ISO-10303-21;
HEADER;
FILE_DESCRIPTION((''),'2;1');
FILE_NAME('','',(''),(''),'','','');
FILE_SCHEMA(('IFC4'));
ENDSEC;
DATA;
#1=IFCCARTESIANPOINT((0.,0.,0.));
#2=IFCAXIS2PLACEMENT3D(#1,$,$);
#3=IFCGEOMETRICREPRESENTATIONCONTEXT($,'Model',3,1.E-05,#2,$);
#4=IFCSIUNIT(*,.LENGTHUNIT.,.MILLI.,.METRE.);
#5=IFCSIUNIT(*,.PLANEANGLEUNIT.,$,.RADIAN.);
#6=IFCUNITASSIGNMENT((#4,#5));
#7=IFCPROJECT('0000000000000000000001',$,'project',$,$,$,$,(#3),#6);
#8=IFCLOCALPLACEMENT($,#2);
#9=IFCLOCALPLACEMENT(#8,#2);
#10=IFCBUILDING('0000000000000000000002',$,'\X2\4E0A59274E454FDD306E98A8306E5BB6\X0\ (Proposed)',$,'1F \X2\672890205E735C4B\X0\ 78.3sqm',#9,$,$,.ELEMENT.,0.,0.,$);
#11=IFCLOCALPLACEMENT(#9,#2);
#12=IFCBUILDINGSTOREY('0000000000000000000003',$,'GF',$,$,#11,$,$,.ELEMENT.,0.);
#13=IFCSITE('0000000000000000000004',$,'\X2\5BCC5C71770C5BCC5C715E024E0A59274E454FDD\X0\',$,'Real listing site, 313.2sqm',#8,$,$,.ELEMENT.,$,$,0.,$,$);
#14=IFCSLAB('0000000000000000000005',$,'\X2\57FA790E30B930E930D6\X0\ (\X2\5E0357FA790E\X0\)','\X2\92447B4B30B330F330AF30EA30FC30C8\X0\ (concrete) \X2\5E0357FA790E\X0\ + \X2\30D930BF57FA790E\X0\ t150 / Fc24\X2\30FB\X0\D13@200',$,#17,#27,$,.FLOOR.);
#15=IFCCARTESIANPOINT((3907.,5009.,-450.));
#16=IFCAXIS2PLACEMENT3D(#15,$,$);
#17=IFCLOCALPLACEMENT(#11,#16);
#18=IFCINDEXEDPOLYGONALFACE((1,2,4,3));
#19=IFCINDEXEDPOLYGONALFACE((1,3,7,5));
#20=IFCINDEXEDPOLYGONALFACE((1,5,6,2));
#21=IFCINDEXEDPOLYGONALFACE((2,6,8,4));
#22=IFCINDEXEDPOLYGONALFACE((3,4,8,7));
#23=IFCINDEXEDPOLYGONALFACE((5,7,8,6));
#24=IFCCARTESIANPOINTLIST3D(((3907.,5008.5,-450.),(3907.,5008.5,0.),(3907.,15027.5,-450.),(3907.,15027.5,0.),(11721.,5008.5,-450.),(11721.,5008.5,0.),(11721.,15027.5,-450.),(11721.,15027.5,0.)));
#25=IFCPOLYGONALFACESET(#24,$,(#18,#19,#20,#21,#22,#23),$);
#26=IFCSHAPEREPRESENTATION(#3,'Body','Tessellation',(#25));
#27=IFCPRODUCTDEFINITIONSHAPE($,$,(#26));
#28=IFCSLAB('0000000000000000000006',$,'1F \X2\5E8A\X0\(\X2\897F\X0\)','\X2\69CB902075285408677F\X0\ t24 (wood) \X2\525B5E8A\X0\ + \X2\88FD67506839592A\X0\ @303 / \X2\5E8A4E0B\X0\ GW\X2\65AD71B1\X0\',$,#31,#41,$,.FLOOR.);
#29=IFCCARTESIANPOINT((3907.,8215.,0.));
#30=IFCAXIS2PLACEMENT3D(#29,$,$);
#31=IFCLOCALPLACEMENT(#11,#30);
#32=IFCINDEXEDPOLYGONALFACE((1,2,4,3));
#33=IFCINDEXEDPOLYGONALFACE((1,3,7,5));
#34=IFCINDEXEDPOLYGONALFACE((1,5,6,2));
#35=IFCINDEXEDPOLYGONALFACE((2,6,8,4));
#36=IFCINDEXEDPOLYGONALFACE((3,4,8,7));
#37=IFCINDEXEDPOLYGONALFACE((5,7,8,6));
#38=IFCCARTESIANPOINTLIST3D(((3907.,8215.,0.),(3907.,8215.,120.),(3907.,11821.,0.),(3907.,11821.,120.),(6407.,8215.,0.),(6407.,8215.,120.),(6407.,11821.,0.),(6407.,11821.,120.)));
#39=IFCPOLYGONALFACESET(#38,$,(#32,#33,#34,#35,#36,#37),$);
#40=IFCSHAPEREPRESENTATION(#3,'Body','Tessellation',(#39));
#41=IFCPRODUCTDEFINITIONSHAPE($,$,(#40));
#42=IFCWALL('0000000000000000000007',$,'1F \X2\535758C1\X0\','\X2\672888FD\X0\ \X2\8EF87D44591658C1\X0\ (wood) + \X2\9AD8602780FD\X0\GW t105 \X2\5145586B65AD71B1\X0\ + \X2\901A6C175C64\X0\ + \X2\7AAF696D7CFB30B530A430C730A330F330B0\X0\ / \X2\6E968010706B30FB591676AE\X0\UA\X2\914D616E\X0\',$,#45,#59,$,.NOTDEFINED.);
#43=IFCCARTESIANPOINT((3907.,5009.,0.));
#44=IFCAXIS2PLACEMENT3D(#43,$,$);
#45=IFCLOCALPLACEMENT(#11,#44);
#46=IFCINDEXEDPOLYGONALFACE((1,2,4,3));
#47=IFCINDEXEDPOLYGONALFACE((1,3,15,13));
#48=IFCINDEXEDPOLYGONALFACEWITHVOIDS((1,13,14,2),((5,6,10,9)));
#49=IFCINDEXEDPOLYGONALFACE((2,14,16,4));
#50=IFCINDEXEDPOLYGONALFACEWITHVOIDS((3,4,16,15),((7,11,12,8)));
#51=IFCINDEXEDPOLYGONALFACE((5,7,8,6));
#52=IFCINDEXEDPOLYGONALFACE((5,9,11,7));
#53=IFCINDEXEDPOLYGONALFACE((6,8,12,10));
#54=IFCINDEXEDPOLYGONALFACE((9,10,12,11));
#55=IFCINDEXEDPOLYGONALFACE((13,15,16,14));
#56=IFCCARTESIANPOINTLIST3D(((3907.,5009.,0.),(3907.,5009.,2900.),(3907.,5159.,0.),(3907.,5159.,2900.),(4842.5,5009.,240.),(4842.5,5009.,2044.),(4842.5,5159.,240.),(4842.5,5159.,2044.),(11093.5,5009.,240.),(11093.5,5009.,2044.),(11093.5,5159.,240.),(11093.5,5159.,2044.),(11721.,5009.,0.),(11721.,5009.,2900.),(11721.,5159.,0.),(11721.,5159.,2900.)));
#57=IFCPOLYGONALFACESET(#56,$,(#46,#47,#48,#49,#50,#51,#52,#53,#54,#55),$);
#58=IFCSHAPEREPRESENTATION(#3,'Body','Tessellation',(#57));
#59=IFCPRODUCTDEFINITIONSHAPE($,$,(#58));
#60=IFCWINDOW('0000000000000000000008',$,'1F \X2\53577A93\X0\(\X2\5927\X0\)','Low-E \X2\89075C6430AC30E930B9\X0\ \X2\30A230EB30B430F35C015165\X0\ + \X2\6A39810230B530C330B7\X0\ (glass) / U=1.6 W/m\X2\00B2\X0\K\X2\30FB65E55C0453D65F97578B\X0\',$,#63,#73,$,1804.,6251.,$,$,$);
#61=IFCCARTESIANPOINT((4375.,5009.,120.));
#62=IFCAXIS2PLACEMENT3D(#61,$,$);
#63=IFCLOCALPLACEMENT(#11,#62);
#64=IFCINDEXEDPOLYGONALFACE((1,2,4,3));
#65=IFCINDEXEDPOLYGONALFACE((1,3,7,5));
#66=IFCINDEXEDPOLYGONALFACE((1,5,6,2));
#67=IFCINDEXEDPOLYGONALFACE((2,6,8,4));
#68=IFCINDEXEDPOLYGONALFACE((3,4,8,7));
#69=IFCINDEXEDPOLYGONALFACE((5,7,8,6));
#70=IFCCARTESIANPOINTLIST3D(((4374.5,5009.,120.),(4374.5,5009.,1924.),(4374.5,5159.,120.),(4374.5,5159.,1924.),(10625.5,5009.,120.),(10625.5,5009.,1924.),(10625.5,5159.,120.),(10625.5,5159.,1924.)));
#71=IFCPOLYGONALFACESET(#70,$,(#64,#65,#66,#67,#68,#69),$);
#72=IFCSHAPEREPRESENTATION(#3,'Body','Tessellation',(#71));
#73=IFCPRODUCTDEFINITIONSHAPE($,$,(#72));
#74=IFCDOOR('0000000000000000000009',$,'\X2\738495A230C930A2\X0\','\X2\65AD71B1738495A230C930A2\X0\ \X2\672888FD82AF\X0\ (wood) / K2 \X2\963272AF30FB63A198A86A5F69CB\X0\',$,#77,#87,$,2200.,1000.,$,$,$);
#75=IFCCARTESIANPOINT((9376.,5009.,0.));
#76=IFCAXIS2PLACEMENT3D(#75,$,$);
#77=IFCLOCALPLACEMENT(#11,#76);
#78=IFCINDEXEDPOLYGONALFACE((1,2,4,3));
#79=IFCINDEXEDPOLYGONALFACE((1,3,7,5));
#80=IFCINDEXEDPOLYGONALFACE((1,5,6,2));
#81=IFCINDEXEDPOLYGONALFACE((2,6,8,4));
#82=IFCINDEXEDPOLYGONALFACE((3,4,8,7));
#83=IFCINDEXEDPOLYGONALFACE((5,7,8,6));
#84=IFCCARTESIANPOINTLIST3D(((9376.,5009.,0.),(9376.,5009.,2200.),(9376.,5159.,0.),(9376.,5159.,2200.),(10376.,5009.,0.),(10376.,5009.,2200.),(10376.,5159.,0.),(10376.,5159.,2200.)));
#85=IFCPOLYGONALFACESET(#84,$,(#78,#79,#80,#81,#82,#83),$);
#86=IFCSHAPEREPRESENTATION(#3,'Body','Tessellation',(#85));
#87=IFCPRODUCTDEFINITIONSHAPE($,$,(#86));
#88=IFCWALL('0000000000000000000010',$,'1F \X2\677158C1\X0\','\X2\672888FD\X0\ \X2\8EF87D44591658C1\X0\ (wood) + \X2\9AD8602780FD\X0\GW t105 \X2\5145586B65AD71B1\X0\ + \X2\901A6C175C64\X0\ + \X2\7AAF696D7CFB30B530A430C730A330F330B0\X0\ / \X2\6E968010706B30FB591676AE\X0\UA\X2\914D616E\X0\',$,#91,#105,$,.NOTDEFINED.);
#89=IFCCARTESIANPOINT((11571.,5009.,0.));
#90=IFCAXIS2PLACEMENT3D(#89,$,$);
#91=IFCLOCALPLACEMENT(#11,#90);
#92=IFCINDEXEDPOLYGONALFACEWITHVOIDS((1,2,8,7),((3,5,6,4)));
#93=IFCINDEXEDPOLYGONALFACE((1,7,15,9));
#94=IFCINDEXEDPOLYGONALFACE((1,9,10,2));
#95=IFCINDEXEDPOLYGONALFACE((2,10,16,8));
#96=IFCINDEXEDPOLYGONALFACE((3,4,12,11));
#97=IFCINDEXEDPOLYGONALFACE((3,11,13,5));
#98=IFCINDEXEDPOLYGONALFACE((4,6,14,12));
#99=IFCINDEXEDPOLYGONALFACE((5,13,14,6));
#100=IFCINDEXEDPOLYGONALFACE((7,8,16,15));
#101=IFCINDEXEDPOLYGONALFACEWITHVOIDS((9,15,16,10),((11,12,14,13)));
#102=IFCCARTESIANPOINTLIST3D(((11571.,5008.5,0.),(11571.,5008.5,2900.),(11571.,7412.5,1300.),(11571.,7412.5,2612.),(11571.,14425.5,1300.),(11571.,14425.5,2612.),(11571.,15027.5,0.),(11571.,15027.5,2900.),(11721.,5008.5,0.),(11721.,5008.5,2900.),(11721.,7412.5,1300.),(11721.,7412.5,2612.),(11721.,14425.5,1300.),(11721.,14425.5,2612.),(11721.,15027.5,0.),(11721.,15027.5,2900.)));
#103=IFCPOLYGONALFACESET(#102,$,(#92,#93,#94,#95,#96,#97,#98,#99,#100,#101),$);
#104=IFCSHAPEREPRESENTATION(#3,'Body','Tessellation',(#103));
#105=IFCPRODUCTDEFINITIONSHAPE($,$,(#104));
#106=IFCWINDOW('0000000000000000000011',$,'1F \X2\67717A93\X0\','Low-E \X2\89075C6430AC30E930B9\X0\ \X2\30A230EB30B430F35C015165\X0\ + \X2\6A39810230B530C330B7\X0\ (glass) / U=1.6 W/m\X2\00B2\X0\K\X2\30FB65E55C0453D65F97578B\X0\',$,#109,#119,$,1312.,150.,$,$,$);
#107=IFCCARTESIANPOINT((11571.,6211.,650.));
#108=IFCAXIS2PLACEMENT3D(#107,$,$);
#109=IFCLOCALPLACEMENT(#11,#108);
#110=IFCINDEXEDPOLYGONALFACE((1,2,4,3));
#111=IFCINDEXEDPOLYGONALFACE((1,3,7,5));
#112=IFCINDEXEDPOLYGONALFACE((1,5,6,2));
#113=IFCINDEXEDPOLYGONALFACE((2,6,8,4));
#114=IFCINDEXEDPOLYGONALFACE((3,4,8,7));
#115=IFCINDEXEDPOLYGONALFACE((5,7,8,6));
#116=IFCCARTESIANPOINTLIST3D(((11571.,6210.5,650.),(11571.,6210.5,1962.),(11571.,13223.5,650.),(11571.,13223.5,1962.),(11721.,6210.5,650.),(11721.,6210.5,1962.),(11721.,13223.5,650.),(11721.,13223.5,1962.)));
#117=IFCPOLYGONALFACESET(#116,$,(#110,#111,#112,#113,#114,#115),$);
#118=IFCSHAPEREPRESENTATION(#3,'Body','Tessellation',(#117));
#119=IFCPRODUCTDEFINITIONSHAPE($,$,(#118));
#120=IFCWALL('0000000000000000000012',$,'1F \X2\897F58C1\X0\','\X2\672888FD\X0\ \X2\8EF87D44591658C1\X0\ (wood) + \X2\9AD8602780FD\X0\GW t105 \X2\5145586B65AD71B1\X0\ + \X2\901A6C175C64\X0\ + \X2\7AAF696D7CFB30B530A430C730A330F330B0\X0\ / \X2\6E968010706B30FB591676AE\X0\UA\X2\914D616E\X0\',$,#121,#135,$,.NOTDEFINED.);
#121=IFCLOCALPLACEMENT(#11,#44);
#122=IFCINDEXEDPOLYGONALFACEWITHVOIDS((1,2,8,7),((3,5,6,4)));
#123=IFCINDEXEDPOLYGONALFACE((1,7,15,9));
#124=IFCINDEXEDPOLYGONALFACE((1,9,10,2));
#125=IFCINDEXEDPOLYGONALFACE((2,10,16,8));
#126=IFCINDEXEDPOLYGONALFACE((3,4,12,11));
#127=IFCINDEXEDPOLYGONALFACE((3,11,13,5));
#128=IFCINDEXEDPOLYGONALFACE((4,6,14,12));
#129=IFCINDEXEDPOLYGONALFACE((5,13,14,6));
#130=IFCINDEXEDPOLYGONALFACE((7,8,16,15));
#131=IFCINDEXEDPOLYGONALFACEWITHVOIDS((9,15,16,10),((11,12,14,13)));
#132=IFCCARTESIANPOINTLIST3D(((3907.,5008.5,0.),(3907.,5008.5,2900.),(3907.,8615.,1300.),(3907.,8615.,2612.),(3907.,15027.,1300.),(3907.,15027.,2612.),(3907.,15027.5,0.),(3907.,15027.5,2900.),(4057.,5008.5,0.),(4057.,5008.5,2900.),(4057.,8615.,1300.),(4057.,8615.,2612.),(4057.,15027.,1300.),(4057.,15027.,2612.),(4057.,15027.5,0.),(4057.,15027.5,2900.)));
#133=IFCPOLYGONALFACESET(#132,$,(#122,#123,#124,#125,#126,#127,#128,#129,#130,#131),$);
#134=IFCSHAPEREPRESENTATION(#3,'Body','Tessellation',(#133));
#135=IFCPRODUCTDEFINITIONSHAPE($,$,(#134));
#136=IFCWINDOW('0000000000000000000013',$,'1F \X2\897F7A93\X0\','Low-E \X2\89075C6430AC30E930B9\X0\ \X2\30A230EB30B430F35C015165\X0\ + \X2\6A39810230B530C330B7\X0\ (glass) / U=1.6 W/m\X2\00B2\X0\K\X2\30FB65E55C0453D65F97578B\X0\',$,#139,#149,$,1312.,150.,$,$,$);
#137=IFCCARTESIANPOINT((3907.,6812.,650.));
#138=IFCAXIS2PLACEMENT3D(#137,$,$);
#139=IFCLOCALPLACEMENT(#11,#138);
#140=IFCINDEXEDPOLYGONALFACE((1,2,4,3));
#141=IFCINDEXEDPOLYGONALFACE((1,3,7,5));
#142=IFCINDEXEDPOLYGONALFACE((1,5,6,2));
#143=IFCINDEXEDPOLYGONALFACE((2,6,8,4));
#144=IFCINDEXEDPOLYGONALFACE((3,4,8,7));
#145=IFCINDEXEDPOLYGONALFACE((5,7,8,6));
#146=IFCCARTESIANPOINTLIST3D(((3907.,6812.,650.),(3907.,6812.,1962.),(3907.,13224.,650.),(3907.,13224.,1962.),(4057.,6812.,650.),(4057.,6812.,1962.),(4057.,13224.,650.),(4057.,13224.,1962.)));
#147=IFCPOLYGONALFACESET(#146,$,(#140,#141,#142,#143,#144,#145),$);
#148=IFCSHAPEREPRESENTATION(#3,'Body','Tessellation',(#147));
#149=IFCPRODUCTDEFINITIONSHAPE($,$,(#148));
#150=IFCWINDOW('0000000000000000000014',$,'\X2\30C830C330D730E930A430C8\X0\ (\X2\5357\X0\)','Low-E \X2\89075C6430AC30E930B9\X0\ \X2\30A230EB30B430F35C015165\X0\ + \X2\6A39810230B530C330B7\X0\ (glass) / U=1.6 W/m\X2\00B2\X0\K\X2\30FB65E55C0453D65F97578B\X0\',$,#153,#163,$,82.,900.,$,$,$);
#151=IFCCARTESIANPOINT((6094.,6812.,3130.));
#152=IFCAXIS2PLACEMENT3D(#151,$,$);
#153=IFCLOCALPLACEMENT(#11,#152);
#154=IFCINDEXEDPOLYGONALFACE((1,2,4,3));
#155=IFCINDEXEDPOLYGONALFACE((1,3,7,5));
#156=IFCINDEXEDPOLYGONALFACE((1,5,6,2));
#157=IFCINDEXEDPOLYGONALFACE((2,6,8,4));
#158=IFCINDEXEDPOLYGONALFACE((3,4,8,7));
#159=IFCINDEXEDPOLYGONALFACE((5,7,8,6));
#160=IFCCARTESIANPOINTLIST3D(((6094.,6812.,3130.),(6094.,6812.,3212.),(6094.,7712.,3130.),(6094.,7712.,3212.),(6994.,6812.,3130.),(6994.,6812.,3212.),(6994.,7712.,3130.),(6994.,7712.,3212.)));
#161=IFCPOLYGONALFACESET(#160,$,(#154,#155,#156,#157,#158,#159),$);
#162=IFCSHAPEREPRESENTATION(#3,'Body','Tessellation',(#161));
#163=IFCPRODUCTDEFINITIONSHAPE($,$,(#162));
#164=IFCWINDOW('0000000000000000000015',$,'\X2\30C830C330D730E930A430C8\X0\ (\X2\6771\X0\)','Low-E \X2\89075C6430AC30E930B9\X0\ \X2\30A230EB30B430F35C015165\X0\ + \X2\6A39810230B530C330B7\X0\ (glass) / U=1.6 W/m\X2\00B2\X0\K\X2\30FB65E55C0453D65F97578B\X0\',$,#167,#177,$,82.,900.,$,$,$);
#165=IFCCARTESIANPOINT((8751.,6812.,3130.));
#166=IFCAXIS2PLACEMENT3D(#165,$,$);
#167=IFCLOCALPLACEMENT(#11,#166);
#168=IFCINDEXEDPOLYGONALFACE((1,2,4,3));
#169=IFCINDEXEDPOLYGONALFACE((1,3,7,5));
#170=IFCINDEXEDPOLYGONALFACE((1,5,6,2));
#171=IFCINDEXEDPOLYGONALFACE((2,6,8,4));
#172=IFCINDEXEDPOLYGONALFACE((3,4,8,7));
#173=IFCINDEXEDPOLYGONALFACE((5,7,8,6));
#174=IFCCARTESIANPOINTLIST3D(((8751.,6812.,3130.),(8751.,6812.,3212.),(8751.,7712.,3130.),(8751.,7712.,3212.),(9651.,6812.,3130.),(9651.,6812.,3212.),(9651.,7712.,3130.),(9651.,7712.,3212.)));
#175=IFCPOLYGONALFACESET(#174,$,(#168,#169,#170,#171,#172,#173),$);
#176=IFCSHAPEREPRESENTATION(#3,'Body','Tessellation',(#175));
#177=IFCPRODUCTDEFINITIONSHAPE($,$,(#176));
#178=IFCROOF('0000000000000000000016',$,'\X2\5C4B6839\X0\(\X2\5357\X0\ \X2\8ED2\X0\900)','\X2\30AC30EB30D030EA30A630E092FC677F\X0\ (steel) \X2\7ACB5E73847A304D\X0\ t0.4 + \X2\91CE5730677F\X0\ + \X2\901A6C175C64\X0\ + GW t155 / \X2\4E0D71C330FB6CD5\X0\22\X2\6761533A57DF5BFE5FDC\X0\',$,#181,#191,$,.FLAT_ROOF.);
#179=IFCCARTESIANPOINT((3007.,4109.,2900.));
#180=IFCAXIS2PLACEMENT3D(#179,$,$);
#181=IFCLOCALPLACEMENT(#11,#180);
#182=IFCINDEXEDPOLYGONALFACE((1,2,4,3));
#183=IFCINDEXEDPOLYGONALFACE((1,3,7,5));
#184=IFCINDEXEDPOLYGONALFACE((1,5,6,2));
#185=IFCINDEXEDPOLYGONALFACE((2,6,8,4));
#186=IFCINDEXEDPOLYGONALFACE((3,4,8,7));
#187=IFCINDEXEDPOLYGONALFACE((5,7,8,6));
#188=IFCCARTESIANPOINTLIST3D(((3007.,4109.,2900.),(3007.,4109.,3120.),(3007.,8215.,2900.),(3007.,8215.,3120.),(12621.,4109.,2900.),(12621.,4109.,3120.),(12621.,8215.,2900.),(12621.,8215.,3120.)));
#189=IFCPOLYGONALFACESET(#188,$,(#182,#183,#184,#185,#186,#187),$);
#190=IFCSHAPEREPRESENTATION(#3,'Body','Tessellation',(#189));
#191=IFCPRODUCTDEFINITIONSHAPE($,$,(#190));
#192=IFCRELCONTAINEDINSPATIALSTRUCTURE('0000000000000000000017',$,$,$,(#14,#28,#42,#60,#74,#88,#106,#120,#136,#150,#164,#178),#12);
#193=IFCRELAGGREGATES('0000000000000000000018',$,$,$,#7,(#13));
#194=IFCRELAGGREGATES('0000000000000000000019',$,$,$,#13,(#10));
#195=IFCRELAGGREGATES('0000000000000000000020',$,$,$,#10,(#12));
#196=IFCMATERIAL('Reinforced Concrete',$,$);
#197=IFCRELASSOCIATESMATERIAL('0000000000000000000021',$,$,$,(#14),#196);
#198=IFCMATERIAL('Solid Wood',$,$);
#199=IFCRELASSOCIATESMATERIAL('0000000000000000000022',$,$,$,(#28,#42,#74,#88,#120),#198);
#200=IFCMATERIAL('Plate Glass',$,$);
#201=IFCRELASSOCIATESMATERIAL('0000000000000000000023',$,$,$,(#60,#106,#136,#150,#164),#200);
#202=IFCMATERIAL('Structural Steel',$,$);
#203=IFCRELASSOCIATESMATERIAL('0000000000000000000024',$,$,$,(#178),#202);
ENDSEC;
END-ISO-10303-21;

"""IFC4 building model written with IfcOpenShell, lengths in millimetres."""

from ifc_helpers import new_model, si_unit, frame, frame_2d, origin, place, context, project, spatial, rectangle, extrude, material, element, fill, save


model = new_model("IFC4")

# Units and contexts
model_context = context("Model", 3, precision=1e-05, world=origin())
ifc_project = project(units=[si_unit("LENGTHUNIT", "METRE", prefix="MILLI"), si_unit("PLANEANGLEUNIT", "RADIAN")], contexts=[model_context])

# Site, building, storey
site_placement = place(None, origin())
site = spatial("IfcSite", under=ifc_project, at=site_placement, Name="富山県富山市上大久保", ObjectType="Real listing site, 313.2sqm", CompositionType="ELEMENT", RefElevation=0.0)
building_placement = place(site_placement, origin())
building = spatial("IfcBuilding", under=site, at=building_placement, Name="上大久保の風の家 (Proposed)", ObjectType="1F 木造平屋 78.3sqm", CompositionType="ELEMENT", ElevationOfRefHeight=0.0, ElevationOfTerrain=0.0)
storey_placement = place(building_placement, origin())
storey = spatial("IfcBuildingStorey", under=building, at=storey_placement, Name="GF", CompositionType="ELEMENT", Elevation=0.0)

# Slabs
ifc_material_1 = material(Name="Reinforced Concrete")
slab_1_placement = place(storey_placement, frame((3907.0, 5009.0, -450.0)))
element("IfcSlab", 1, at=slab_1_placement, inside=storey, material=ifc_material_1, Name="基礎スラブ (布基礎)", Description="鉄筋コンクリート (concrete) 布基礎 + ベタ基礎 t150 / Fc24・D13@200", PredefinedType="FLOOR", context=model_context, shape_type="SweptSolid", body=[
    extrude(rectangle(XDim=7814.0, YDim=10019.0, at=frame_2d((3907.0, 5009.0))), frame((3907.0, 5009.0, -450.0)), (0.0, 0.0, 1.0), 450.0),
])
ifc_material_2 = material(Name="Solid Wood")
slab_2_placement = place(storey_placement, frame((3907.0, 8215.0, 0.0)))
element("IfcSlab", 2, at=slab_2_placement, inside=storey, material=ifc_material_2, Name="1F 床(西)", Description="構造用合板 t24 (wood) 剛床 + 製材根太 @303 / 床下 GW断熱", PredefinedType="FLOOR", context=model_context, shape_type="SweptSolid", body=[
    extrude(rectangle(XDim=2500.0, YDim=3606.0, at=frame_2d((1250.0, 1803.0))), frame((3907.0, 8215.0, 0.0)), (0.0, 0.0, 1.0), 120.0),
])

# Wall, openings, window, door
wall_1_placement = place(storey_placement, frame((3907.0, 5009.0, 0.0)))
wall_1 = element("IfcWall", 3, at=wall_1_placement, inside=storey, material=ifc_material_2, Name="1F 南壁", Description="木製 軸組外壁 (wood) + 高性能GW t105 充填断熱 + 通気層 + 窯業系サイディング / 準耐火・外皮UA配慮", PredefinedType="NOTDEFINED", context=model_context, shape_type="SweptSolid", body=[
    extrude(rectangle(XDim=7814.0, YDim=150.0, at=frame_2d((3907.0, 75.0))), frame((3907.0, 5009.0, 0.0)), (0.0, 0.0, 1.0), 2900.0),
])
opening_1_placement = place(storey_placement, frame((4375.0, 5009.0, 120.0)))
opening_1 = element("IfcOpeningElement", 4, at=opening_1_placement, cuts=wall_1, PredefinedType="NOTDEFINED", context=model_context, shape_type="SweptSolid", body=[
    extrude(rectangle(XDim=6251.0, YDim=150.0, at=frame_2d((3125.0, 75.0))), frame((4375.0, 5009.0, 120.0)), (0.0, 0.0, 1.0), 1804.0),
])
opening_2_placement = place(storey_placement, frame((9376.0, 5009.0, 0.0)))
opening_2 = element("IfcOpeningElement", 5, at=opening_2_placement, cuts=wall_1, PredefinedType="NOTDEFINED", context=model_context, shape_type="SweptSolid", body=[
    extrude(rectangle(XDim=1000.0, YDim=150.0, at=frame_2d((500.0, 75.0))), frame((9376.0, 5009.0, 0.0)), (0.0, 0.0, 1.0), 2200.0),
])
ifc_material_3 = material(Name="Plate Glass")
window_1_placement = place(storey_placement, frame((4375.0, 5009.0, 120.0)))
window_1 = element("IfcWindow", 6, at=window_1_placement, inside=storey, material=ifc_material_3, Name="1F 南窓(大)", Description="Low-E 複層ガラス アルゴン封入 + 樹脂サッシ (glass) / U=1.6 W/m²K・日射取得型", OverallHeight=1804.0, OverallWidth=6251.0, context=model_context, shape_type="SweptSolid", body=[
    extrude(rectangle(XDim=6251.0, YDim=150.0, at=frame_2d((3125.0, 75.0))), frame((4375.0, 5009.0, 120.0)), (0.0, 0.0, 1.0), 1804.0),
])
fill(opening_1, window_1)
door_placement = place(storey_placement, frame((9376.0, 5009.0, 0.0)))
door = element("IfcDoor", 7, at=door_placement, inside=storey, material=ifc_material_2, Name="玄関ドア", Description="断熱玄関ドア 木製芯 (wood) / K2 防犯・採風機構", OverallHeight=2200.0, OverallWidth=1000.0, context=model_context, shape_type="SweptSolid", body=[
    extrude(rectangle(XDim=1000.0, YDim=150.0, at=frame_2d((500.0, 75.0))), frame((9376.0, 5009.0, 0.0)), (0.0, 0.0, 1.0), 2200.0),
])
fill(opening_2, door)

# Walls, openings, windows
wall_2_placement = place(storey_placement, frame((11571.0, 5009.0, 0.0)))
wall_2 = element("IfcWall", 8, at=wall_2_placement, inside=storey, material=ifc_material_2, Name="1F 東壁", Description="木製 軸組外壁 (wood) + 高性能GW t105 充填断熱 + 通気層 + 窯業系サイディング / 準耐火・外皮UA配慮", PredefinedType="NOTDEFINED", context=model_context, shape_type="SweptSolid", body=[
    extrude(rectangle(XDim=150.0, YDim=10019.0, at=frame_2d((75.0, 5009.0))), frame((11571.0, 5009.0, 0.0)), (0.0, 0.0, 1.0), 2900.0),
])
opening_3_placement = place(storey_placement, frame((11571.0, 6211.0, 650.0)))
opening_3 = element("IfcOpeningElement", 9, at=opening_3_placement, cuts=wall_2, PredefinedType="NOTDEFINED", context=model_context, shape_type="SweptSolid", body=[
    extrude(rectangle(XDim=150.0, YDim=7013.0, at=frame_2d((75.0, 3506.0))), frame((11571.0, 6211.0, 650.0)), (0.0, 0.0, 1.0), 1312.0),
])
window_2_placement = place(storey_placement, frame((11571.0, 6211.0, 650.0)))
window_2 = element("IfcWindow", 10, at=window_2_placement, inside=storey, material=ifc_material_3, Name="1F 東窓", Description="Low-E 複層ガラス アルゴン封入 + 樹脂サッシ (glass) / U=1.6 W/m²K・日射取得型", OverallHeight=1312.0, OverallWidth=150.0, context=model_context, shape_type="SweptSolid", body=[
    extrude(rectangle(XDim=150.0, YDim=7013.0, at=frame_2d((75.0, 3506.0))), frame((11571.0, 6211.0, 650.0)), (0.0, 0.0, 1.0), 1312.0),
])
fill(opening_3, window_2)
wall_3_placement = place(storey_placement, frame((3907.0, 5009.0, 0.0)))
wall_3 = element("IfcWall", 11, at=wall_3_placement, inside=storey, material=ifc_material_2, Name="1F 西壁", Description="木製 軸組外壁 (wood) + 高性能GW t105 充填断熱 + 通気層 + 窯業系サイディング / 準耐火・外皮UA配慮", PredefinedType="NOTDEFINED", context=model_context, shape_type="SweptSolid", body=[
    extrude(rectangle(XDim=150.0, YDim=10019.0, at=frame_2d((75.0, 5009.0))), frame((3907.0, 5009.0, 0.0)), (0.0, 0.0, 1.0), 2900.0),
])
opening_4_placement = place(storey_placement, frame((3907.0, 6812.0, 650.0)))
opening_4 = element("IfcOpeningElement", 12, at=opening_4_placement, cuts=wall_3, PredefinedType="NOTDEFINED", context=model_context, shape_type="SweptSolid", body=[
    extrude(rectangle(XDim=150.0, YDim=6412.0, at=frame_2d((75.0, 3206.0))), frame((3907.0, 6812.0, 650.0)), (0.0, 0.0, 1.0), 1312.0),
])
window_3_placement = place(storey_placement, frame((3907.0, 6812.0, 650.0)))
window_3 = element("IfcWindow", 13, at=window_3_placement, inside=storey, material=ifc_material_3, Name="1F 西窓", Description="Low-E 複層ガラス アルゴン封入 + 樹脂サッシ (glass) / U=1.6 W/m²K・日射取得型", OverallHeight=1312.0, OverallWidth=150.0, context=model_context, shape_type="SweptSolid", body=[
    extrude(rectangle(XDim=150.0, YDim=6412.0, at=frame_2d((75.0, 3206.0))), frame((3907.0, 6812.0, 650.0)), (0.0, 0.0, 1.0), 1312.0),
])
fill(opening_4, window_3)

# Windows
window_4_placement = place(storey_placement, frame((6094.0, 6812.0, 3130.0)))
element("IfcWindow", 14, at=window_4_placement, inside=storey, material=ifc_material_3, Name="トップライト (南)", Description="Low-E 複層ガラス アルゴン封入 + 樹脂サッシ (glass) / U=1.6 W/m²K・日射取得型", OverallHeight=82.0, OverallWidth=900.0, context=model_context, shape_type="SweptSolid", body=[
    extrude(rectangle(XDim=900.0, YDim=900.0, at=frame_2d((450.0, 450.0))), frame((6094.0, 6812.0, 3130.0)), (0.0, 0.0, 1.0), 82.0),
])
window_5_placement = place(storey_placement, frame((8751.0, 6812.0, 3130.0)))
element("IfcWindow", 15, at=window_5_placement, inside=storey, material=ifc_material_3, Name="トップライト (東)", Description="Low-E 複層ガラス アルゴン封入 + 樹脂サッシ (glass) / U=1.6 W/m²K・日射取得型", OverallHeight=82.0, OverallWidth=900.0, context=model_context, shape_type="SweptSolid", body=[
    extrude(rectangle(XDim=900.0, YDim=900.0, at=frame_2d((450.0, 450.0))), frame((8751.0, 6812.0, 3130.0)), (0.0, 0.0, 1.0), 82.0),
])

# Roof
ifc_material_4 = material(Name="Structural Steel")
roof_placement = place(storey_placement, frame((3007.0, 4109.0, 2900.0)))
element("IfcRoof", 16, at=roof_placement, inside=storey, material=ifc_material_4, Name="屋根(南 軒900)", Description="ガルバリウム鋼板 (steel) 立平葺き t0.4 + 野地板 + 通気層 + GW t155 / 不燃・法22条区域対応", PredefinedType="FLAT_ROOF", context=model_context, shape_type="SweptSolid", body=[
    extrude(rectangle(XDim=9614.0, YDim=4106.0, at=frame_2d((4807.0, 2053.0))), frame((3007.0, 4109.0, 2900.0)), (0.0, 0.0, 1.0), 220.0),
])

save(model, "model.ifc")
